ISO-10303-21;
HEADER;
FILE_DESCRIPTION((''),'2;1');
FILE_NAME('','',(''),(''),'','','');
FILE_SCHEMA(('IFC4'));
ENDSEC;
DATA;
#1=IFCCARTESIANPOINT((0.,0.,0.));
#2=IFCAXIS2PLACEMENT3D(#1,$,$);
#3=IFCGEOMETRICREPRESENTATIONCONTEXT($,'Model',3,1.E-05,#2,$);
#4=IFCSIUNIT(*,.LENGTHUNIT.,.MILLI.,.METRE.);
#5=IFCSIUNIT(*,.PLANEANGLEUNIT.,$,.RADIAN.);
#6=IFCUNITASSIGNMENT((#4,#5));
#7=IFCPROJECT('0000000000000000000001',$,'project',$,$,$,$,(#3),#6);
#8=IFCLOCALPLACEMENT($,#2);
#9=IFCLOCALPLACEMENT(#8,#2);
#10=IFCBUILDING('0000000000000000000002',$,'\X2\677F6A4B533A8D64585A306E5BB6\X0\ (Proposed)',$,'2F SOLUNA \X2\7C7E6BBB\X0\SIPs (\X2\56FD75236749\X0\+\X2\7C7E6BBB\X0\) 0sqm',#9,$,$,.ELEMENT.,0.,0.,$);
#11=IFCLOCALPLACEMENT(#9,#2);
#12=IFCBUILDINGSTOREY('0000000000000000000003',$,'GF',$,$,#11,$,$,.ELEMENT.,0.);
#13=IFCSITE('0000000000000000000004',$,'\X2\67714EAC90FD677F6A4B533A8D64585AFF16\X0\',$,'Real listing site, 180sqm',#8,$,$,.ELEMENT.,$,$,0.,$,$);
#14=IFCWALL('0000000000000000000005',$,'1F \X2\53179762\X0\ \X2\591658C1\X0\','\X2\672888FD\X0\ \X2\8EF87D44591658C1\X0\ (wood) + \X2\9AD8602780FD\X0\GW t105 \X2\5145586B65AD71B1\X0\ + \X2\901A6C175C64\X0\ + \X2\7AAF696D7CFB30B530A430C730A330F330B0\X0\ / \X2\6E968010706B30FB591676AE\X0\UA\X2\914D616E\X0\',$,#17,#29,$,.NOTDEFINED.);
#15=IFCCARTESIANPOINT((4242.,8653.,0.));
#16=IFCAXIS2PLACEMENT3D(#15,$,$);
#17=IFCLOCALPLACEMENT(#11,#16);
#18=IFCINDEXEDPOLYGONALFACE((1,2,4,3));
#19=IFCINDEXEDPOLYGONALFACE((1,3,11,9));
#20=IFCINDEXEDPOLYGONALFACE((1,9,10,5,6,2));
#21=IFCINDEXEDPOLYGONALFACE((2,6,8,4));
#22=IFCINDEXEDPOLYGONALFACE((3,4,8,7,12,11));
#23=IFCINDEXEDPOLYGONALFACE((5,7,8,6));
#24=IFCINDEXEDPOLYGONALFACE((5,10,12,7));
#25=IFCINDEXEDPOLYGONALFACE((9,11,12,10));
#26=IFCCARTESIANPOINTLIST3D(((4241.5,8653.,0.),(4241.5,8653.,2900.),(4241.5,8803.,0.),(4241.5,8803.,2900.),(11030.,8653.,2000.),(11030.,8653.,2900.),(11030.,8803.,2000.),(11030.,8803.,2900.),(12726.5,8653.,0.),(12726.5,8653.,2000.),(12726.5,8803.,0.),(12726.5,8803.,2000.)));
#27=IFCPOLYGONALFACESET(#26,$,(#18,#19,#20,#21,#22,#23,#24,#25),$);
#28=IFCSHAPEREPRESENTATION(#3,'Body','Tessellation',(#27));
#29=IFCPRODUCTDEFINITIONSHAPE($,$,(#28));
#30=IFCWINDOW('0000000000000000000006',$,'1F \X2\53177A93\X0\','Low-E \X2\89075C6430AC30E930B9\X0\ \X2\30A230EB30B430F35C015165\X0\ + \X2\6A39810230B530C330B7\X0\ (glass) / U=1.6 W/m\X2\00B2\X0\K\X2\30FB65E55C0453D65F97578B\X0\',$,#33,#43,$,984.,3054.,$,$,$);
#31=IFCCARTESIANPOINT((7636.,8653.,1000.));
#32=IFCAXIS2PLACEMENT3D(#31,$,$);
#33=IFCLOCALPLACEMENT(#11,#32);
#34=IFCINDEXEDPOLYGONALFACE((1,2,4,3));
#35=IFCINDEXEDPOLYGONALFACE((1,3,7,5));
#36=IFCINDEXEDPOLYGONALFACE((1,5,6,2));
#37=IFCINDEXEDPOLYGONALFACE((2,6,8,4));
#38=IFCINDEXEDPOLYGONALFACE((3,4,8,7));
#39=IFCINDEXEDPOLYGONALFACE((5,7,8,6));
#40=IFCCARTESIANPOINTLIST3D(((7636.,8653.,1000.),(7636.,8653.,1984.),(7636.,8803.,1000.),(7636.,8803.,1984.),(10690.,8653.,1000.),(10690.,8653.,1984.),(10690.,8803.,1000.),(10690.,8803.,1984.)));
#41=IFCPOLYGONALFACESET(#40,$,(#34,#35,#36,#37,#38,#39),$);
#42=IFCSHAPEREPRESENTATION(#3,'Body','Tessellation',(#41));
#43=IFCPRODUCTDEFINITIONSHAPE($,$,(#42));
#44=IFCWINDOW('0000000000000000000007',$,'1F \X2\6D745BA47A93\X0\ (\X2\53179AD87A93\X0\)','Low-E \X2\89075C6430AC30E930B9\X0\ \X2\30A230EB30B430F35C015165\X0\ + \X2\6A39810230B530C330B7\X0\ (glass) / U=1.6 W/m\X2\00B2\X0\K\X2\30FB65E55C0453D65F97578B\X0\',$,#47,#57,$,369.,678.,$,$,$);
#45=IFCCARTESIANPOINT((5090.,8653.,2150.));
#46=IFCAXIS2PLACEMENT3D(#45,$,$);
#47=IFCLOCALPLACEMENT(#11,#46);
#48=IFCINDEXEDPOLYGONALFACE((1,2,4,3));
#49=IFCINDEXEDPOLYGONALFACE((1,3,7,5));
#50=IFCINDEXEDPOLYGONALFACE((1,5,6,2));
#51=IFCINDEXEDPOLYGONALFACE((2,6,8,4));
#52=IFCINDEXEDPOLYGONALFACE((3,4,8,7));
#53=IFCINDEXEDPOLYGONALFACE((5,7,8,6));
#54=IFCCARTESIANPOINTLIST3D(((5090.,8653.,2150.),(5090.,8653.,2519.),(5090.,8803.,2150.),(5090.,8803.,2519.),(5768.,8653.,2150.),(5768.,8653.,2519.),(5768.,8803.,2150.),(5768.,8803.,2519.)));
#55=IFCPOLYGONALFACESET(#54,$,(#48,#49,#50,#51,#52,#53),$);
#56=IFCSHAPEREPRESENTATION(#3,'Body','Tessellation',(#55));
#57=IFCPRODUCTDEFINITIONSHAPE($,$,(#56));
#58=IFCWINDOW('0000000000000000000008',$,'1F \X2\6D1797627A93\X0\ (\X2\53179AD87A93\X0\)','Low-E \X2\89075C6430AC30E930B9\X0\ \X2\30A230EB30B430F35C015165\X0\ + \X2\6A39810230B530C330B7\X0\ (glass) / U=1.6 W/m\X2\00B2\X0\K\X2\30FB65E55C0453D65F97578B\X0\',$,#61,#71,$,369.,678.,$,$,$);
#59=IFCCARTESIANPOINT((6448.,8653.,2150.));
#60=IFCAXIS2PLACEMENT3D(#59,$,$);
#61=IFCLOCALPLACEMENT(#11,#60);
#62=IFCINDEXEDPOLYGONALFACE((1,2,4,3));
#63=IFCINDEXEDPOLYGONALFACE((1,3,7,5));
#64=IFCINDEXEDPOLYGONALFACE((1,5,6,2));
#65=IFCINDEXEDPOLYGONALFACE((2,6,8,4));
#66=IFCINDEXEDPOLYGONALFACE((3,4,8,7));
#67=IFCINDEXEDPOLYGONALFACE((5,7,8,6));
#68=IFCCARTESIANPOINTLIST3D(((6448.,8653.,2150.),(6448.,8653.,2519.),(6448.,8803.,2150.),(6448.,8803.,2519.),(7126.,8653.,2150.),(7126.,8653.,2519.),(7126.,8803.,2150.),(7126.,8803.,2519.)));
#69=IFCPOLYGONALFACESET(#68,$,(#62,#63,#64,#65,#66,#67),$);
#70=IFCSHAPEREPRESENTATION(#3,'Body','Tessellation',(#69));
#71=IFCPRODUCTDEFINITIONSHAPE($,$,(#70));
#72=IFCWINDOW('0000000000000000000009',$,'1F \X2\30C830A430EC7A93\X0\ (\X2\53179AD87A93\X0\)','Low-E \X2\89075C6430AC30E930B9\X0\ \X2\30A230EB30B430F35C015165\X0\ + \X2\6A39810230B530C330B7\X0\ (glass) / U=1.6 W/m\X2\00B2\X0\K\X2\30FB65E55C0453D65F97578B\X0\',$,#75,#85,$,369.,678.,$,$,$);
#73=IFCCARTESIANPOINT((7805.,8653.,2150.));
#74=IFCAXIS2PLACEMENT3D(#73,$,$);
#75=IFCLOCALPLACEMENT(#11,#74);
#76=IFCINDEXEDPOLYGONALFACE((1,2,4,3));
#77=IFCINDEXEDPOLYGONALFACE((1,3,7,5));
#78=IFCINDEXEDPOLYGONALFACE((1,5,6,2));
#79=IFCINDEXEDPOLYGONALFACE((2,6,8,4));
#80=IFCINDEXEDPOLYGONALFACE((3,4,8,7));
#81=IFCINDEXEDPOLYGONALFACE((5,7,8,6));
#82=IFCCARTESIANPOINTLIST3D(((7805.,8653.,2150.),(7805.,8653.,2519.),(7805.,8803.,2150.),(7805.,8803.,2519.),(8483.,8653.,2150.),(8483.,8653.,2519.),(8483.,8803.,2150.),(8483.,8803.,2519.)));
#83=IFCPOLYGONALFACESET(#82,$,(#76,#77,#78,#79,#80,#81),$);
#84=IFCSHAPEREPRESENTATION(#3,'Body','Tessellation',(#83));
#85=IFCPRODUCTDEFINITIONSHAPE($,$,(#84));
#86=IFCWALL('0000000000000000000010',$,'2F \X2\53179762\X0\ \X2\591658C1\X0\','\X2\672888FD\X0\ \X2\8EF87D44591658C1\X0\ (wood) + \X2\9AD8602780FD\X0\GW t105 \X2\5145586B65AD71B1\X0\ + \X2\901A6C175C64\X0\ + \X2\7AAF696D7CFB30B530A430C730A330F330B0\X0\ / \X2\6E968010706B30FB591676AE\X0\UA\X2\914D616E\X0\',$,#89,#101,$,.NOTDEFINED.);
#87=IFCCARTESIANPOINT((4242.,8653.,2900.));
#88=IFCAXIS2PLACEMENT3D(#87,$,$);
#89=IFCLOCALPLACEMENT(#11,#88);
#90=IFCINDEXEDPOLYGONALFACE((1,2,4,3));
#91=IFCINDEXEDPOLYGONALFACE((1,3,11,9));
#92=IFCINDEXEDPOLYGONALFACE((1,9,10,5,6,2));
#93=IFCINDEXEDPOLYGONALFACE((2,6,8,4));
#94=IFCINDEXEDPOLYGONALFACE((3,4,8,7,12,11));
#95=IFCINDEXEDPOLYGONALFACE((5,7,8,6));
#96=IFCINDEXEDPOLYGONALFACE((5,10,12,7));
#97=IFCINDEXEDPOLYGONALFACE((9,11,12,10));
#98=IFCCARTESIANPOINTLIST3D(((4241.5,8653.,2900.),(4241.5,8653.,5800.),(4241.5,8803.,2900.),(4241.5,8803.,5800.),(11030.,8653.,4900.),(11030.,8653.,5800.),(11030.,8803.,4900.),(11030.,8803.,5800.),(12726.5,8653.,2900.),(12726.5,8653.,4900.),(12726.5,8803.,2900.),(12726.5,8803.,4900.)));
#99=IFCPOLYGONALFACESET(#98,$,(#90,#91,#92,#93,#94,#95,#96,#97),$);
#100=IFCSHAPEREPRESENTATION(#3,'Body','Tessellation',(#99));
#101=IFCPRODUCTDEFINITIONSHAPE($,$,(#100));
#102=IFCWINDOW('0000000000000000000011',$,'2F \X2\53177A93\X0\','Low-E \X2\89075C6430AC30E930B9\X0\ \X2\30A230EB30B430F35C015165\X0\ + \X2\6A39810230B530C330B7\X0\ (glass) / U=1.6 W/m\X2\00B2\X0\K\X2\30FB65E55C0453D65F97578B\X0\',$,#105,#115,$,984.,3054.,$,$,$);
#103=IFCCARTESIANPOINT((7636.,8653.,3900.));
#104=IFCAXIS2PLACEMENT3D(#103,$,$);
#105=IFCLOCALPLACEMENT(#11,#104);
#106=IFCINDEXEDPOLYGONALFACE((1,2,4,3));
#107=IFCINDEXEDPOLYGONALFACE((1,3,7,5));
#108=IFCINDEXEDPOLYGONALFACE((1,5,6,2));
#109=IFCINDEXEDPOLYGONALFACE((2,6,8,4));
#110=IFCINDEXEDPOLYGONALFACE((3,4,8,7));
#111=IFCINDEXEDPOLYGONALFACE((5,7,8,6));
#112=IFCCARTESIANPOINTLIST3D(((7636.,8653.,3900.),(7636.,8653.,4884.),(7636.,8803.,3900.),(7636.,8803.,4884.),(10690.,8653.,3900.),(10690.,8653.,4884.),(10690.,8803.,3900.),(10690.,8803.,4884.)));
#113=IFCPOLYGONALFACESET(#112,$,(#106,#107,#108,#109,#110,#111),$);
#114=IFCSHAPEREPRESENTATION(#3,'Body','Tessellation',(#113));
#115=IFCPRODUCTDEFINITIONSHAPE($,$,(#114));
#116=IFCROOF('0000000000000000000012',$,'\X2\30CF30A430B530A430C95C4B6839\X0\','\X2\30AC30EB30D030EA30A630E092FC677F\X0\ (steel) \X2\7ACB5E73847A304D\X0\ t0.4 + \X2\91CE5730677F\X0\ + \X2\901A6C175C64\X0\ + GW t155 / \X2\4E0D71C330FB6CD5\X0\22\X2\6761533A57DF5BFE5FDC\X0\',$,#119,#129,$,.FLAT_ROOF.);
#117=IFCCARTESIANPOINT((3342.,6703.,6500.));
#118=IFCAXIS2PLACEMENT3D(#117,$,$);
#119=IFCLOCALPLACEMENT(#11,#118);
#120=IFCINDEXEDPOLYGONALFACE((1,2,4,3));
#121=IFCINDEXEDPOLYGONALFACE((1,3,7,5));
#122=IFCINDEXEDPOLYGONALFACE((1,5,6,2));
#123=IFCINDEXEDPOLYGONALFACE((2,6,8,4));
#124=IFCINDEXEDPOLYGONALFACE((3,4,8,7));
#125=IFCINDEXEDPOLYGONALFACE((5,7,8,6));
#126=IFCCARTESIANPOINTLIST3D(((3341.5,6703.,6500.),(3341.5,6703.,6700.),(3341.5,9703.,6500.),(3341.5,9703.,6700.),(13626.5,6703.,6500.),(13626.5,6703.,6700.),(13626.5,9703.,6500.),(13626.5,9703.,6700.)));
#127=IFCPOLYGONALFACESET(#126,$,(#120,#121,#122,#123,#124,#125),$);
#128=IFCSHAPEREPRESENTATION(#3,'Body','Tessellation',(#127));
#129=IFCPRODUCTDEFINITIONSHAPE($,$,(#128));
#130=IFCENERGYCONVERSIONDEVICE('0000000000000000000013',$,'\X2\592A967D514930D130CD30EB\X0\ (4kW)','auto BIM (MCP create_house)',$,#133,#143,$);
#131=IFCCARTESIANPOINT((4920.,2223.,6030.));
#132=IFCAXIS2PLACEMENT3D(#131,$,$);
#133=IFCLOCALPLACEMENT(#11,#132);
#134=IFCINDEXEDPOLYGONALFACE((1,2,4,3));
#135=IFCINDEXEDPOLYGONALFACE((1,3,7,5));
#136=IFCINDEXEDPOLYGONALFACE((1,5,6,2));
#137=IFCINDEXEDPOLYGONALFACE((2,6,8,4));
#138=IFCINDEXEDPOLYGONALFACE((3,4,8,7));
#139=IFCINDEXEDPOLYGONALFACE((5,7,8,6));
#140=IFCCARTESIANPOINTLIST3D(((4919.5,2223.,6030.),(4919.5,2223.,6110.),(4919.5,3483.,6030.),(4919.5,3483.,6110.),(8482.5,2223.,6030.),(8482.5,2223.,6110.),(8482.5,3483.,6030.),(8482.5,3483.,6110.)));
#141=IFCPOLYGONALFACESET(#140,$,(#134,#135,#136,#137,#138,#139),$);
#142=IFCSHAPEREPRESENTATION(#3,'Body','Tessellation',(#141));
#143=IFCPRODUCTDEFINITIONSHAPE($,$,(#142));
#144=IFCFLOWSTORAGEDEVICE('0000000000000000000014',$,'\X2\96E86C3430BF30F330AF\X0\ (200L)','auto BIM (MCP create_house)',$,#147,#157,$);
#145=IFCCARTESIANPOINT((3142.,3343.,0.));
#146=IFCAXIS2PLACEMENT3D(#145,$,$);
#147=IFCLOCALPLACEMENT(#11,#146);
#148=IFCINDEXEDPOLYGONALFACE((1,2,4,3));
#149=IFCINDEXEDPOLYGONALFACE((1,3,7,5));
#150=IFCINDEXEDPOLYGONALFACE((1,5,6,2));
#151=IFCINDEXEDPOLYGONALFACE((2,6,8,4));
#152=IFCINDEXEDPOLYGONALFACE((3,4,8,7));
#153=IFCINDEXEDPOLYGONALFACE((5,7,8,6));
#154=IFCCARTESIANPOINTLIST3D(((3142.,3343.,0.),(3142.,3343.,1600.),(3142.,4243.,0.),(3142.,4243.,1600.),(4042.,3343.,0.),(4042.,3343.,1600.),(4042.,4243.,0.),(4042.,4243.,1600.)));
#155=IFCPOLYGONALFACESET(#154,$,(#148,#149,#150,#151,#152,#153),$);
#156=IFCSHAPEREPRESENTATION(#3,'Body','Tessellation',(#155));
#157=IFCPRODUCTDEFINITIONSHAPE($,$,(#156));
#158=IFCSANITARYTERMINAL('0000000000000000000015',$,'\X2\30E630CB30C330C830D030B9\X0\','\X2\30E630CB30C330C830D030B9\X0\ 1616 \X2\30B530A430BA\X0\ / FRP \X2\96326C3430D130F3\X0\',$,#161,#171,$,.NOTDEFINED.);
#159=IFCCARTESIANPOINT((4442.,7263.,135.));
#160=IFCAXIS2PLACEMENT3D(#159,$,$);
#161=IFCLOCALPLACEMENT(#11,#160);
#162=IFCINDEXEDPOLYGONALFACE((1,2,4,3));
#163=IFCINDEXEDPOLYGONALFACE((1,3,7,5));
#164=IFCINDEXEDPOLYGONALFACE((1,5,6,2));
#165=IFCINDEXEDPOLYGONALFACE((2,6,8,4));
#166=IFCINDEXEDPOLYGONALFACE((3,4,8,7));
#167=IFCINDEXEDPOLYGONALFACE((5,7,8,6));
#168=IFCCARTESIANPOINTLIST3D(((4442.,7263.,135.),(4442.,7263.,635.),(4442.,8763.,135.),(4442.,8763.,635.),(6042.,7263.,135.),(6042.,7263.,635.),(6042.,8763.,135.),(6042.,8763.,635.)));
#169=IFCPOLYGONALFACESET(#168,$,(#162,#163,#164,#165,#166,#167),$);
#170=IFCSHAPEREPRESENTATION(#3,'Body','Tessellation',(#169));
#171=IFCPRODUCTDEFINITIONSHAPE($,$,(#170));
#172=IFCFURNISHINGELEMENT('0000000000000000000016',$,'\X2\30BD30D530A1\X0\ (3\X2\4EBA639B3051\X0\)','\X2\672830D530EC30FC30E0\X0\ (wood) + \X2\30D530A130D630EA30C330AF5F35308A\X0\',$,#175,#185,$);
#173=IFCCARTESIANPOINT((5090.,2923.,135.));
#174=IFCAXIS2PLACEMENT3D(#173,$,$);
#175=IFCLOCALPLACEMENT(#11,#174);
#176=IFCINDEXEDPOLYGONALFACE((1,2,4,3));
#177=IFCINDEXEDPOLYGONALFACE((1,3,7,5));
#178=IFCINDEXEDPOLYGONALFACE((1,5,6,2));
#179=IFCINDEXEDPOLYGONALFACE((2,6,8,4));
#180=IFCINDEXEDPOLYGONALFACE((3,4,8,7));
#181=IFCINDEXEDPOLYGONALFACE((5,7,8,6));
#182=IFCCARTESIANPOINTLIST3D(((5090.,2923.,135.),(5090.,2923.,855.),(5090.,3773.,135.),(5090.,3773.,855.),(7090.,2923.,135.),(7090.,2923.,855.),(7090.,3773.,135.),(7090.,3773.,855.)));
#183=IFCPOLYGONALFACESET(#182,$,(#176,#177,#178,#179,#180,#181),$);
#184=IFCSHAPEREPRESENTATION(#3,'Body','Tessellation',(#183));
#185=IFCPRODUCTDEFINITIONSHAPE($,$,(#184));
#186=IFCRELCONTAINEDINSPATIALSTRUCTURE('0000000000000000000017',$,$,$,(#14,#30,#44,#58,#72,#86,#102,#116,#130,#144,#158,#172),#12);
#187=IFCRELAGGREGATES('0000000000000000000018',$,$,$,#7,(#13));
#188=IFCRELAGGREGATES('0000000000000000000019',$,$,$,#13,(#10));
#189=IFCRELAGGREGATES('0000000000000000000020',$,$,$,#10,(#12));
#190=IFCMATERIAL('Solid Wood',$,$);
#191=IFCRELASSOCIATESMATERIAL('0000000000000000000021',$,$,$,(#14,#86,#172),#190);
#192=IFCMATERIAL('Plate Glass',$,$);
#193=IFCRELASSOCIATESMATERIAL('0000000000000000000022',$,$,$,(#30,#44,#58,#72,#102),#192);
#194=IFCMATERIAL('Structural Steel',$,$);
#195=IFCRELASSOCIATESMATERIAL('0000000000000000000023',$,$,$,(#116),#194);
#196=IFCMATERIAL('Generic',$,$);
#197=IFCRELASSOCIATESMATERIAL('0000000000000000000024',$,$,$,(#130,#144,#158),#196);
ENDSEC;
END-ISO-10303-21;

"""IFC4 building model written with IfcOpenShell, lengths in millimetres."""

from ifc_helpers import new_model, si_unit, frame, frame_2d, origin, place, context, project, spatial, rectangle, extrude, material, element, fill, save


model = new_model("IFC4")

# Units and contexts
model_context = context("Model", 3, precision=1e-05, world=origin())
ifc_project = project(units=[si_unit("LENGTHUNIT", "METRE", prefix="MILLI"), si_unit("PLANEANGLEUNIT", "RADIAN")], contexts=[model_context])

# Site, building, storey
site_placement = place(None, origin())
site = spatial("IfcSite", under=ifc_project, at=site_placement, Name="東京都板橋区赤塚６", ObjectType="Real listing site, 180sqm", CompositionType="ELEMENT", RefElevation=0.0)
building_placement = place(site_placement, origin())
building = spatial("IfcBuilding", under=site, at=building_placement, Name="板橋区赤塚の家 (Proposed)", ObjectType="2F SOLUNA 籾殻SIPs (国産杉+籾殻) 0sqm", CompositionType="ELEMENT", ElevationOfRefHeight=0.0, ElevationOfTerrain=0.0)
storey_placement = place(building_placement, origin())
storey = spatial("IfcBuildingStorey", under=building, at=storey_placement, Name="GF", CompositionType="ELEMENT", Elevation=0.0)

# Wall, openings, windows
ifc_material_1 = material(Name="Solid Wood")
wall_1_placement = place(storey_placement, frame((4242.0, 8653.0, 0.0)))
wall_1 = element("IfcWall", 1, at=wall_1_placement, inside=storey, material=ifc_material_1, Name="1F 北面 外壁", Description="木製 軸組外壁 (wood) + 高性能GW t105 充填断熱 + 通気層 + 窯業系サイディング / 準耐火・外皮UA配慮", PredefinedType="NOTDEFINED", context=model_context, shape_type="SweptSolid", body=[
    extrude(rectangle(XDim=8485.0, YDim=150.0, at=frame_2d((4242.0, 75.0))), frame((4242.0, 8653.0, 0.0)), (0.0, 0.0, 1.0), 2900.0),
])
opening_1_placement = place(storey_placement, frame((7636.0, 8653.0, 1000.0)))
opening_1 = element("IfcOpeningElement", 2, at=opening_1_placement, cuts=wall_1, PredefinedType="NOTDEFINED", context=model_context, shape_type="SweptSolid", body=[
    extrude(rectangle(XDim=3054.0, YDim=150.0, at=frame_2d((1527.0, 75.0))), frame((7636.0, 8653.0, 1000.0)), (0.0, 0.0, 1.0), 984.0),
])
opening_2_placement = place(storey_placement, frame((5090.0, 8653.0, 2150.0)))
opening_2 = element("IfcOpeningElement", 3, at=opening_2_placement, cuts=wall_1, PredefinedType="NOTDEFINED", context=model_context, shape_type="SweptSolid", body=[
    extrude(rectangle(XDim=678.0, YDim=150.0, at=frame_2d((339.0, 75.0))), frame((5090.0, 8653.0, 2150.0)), (0.0, 0.0, 1.0), 369.0),
])
opening_3_placement = place(storey_placement, frame((6448.0, 8653.0, 2150.0)))
opening_3 = element("IfcOpeningElement", 4, at=opening_3_placement, cuts=wall_1, PredefinedType="NOTDEFINED", context=model_context, shape_type="SweptSolid", body=[
    extrude(rectangle(XDim=678.0, YDim=150.0, at=frame_2d((339.0, 75.0))), frame((6448.0, 8653.0, 2150.0)), (0.0, 0.0, 1.0), 369.0),
])
opening_4_placement = place(storey_placement, frame((7805.0, 8653.0, 2150.0)))
opening_4 = element("IfcOpeningElement", 5, at=opening_4_placement, cuts=wall_1, PredefinedType="NOTDEFINED", context=model_context, shape_type="SweptSolid", body=[
    extrude(rectangle(XDim=678.0, YDim=150.0, at=frame_2d((339.0, 75.0))), frame((7805.0, 8653.0, 2150.0)), (0.0, 0.0, 1.0), 369.0),
])
ifc_material_2 = material(Name="Plate Glass")
window_1_placement = place(storey_placement, frame((7636.0, 8653.0, 1000.0)))
window_1 = element("IfcWindow", 6, at=window_1_placement, inside=storey, material=ifc_material_2, Name="1F 北窓", Description="Low-E 複層ガラス アルゴン封入 + 樹脂サッシ (glass) / U=1.6 W/m²K・日射取得型", OverallHeight=984.0, OverallWidth=3054.0, context=model_context, shape_type="SweptSolid", body=[
    extrude(rectangle(XDim=3054.0, YDim=150.0, at=frame_2d((1527.0, 75.0))), frame((7636.0, 8653.0, 1000.0)), (0.0, 0.0, 1.0), 984.0),
])
fill(opening_1, window_1)
window_2_placement = place(storey_placement, frame((5090.0, 8653.0, 2150.0)))
window_2 = element("IfcWindow", 7, at=window_2_placement, inside=storey, material=ifc_material_2, Name="1F 浴室窓 (北高窓)", Description="Low-E 複層ガラス アルゴン封入 + 樹脂サッシ (glass) / U=1.6 W/m²K・日射取得型", OverallHeight=369.0, OverallWidth=678.0, context=model_context, shape_type="SweptSolid", body=[
    extrude(rectangle(XDim=678.0, YDim=150.0, at=frame_2d((339.0, 75.0))), frame((5090.0, 8653.0, 2150.0)), (0.0, 0.0, 1.0), 369.0),
])
fill(opening_2, window_2)
window_3_placement = place(storey_placement, frame((6448.0, 8653.0, 2150.0)))
window_3 = element("IfcWindow", 8, at=window_3_placement, inside=storey, material=ifc_material_2, Name="1F 洗面窓 (北高窓)", Description="Low-E 複層ガラス アルゴン封入 + 樹脂サッシ (glass) / U=1.6 W/m²K・日射取得型", OverallHeight=369.0, OverallWidth=678.0, context=model_context, shape_type="SweptSolid", body=[
    extrude(rectangle(XDim=678.0, YDim=150.0, at=frame_2d((339.0, 75.0))), frame((6448.0, 8653.0, 2150.0)), (0.0, 0.0, 1.0), 369.0),
])
fill(opening_3, window_3)
window_4_placement = place(storey_placement, frame((7805.0, 8653.0, 2150.0)))
window_4 = element("IfcWindow", 9, at=window_4_placement, inside=storey, material=ifc_material_2, Name="1F トイレ窓 (北高窓)", Description="Low-E 複層ガラス アルゴン封入 + 樹脂サッシ (glass) / U=1.6 W/m²K・日射取得型", OverallHeight=369.0, OverallWidth=678.0, context=model_context, shape_type="SweptSolid", body=[
    extrude(rectangle(XDim=678.0, YDim=150.0, at=frame_2d((339.0, 75.0))), frame((7805.0, 8653.0, 2150.0)), (0.0, 0.0, 1.0), 369.0),
])
fill(opening_4, window_4)

# Wall, opening, window
wall_2_placement = place(storey_placement, frame((4242.0, 8653.0, 2900.0)))
wall_2 = element("IfcWall", 10, at=wall_2_placement, inside=storey, material=ifc_material_1, Name="2F 北面 外壁", Description="木製 軸組外壁 (wood) + 高性能GW t105 充填断熱 + 通気層 + 窯業系サイディング / 準耐火・外皮UA配慮", PredefinedType="NOTDEFINED", context=model_context, shape_type="SweptSolid", body=[
    extrude(rectangle(XDim=8485.0, YDim=150.0, at=frame_2d((4242.0, 75.0))), frame((4242.0, 8653.0, 2900.0)), (0.0, 0.0, 1.0), 2900.0),
])
opening_5_placement = place(storey_placement, frame((7636.0, 8653.0, 3900.0)))
opening_5 = element("IfcOpeningElement", 11, at=opening_5_placement, cuts=wall_2, PredefinedType="NOTDEFINED", context=model_context, shape_type="SweptSolid", body=[
    extrude(rectangle(XDim=3054.0, YDim=150.0, at=frame_2d((1527.0, 75.0))), frame((7636.0, 8653.0, 3900.0)), (0.0, 0.0, 1.0), 984.0),
])
window_5_placement = place(storey_placement, frame((7636.0, 8653.0, 3900.0)))
window_5 = element("IfcWindow", 12, at=window_5_placement, inside=storey, material=ifc_material_2, Name="2F 北窓", Description="Low-E 複層ガラス アルゴン封入 + 樹脂サッシ (glass) / U=1.6 W/m²K・日射取得型", OverallHeight=984.0, OverallWidth=3054.0, context=model_context, shape_type="SweptSolid", body=[
    extrude(rectangle(XDim=3054.0, YDim=150.0, at=frame_2d((1527.0, 75.0))), frame((7636.0, 8653.0, 3900.0)), (0.0, 0.0, 1.0), 984.0),
])
fill(opening_5, window_5)

# Roof
ifc_material_3 = material(Name="Structural Steel")
roof_placement = place(storey_placement, frame((3342.0, 6703.0, 6500.0)))
element("IfcRoof", 13, at=roof_placement, inside=storey, material=ifc_material_3, Name="ハイサイド屋根", Description="ガルバリウム鋼板 (steel) 立平葺き t0.4 + 野地板 + 通気層 + GW t155 / 不燃・法22条区域対応", PredefinedType="FLAT_ROOF", context=model_context, shape_type="SweptSolid", body=[
    extrude(rectangle(XDim=10285.0, YDim=3000.0, at=frame_2d((5142.0, 1500.0))), frame((3342.0, 6703.0, 6500.0)), (0.0, 0.0, 1.0), 200.0),
])

# Energy conversion device
ifc_material_4 = material(Name="Generic")
energy_conversion_device_placement = place(storey_placement, frame((4920.0, 2223.0, 6030.0)))
element("IfcEnergyConversionDevice", 14, at=energy_conversion_device_placement, inside=storey, material=ifc_material_4, Name="太陽光パネル (4kW)", Description="auto BIM (MCP create_house)", context=model_context, shape_type="SweptSolid", body=[
    extrude(rectangle(XDim=3563.0, YDim=1260.0, at=frame_2d((1781.0, 630.0))), frame((4920.0, 2223.0, 6030.0)), (0.0, 0.0, 1.0), 80.0),
])

# Flow storage device
flow_storage_device_placement = place(storey_placement, frame((3142.0, 3343.0, 0.0)))
element("IfcFlowStorageDevice", 15, at=flow_storage_device_placement, inside=storey, material=ifc_material_4, Name="雨水タンク (200L)", Description="auto BIM (MCP create_house)", context=model_context, shape_type="SweptSolid", body=[
    extrude(rectangle(XDim=900.0, YDim=900.0, at=frame_2d((450.0, 450.0))), frame((3142.0, 3343.0, 0.0)), (0.0, 0.0, 1.0), 1600.0),
])

# Sanitary terminal
sanitary_terminal_placement = place(storey_placement, frame((4442.0, 7263.0, 135.0)))
element("IfcSanitaryTerminal", 16, at=sanitary_terminal_placement, inside=storey, material=ifc_material_4, Name="ユニットバス", Description="ユニットバス 1616 サイズ / FRP 防水パン", PredefinedType="NOTDEFINED", context=model_context, shape_type="SweptSolid", body=[
    extrude(rectangle(XDim=1600.0, YDim=1500.0, at=frame_2d((800.0, 750.0))), frame((4442.0, 7263.0, 135.0)), (0.0, 0.0, 1.0), 500.0),
])

# Furnishing element
furnishing_1_placement = place(storey_placement, frame((5090.0, 2923.0, 135.0)))
element("IfcFurnishingElement", 17, at=furnishing_1_placement, inside=storey, material=ifc_material_1, Name="ソファ (3人掛け)", Description="木フレーム (wood) + ファブリック張り", context=model_context, shape_type="SweptSolid", body=[
    extrude(rectangle(XDim=2000.0, YDim=850.0, at=frame_2d((1000.0, 425.0))), frame((5090.0, 2923.0, 135.0)), (0.0, 0.0, 1.0), 720.0),
])

save(model, "model.ifc")
